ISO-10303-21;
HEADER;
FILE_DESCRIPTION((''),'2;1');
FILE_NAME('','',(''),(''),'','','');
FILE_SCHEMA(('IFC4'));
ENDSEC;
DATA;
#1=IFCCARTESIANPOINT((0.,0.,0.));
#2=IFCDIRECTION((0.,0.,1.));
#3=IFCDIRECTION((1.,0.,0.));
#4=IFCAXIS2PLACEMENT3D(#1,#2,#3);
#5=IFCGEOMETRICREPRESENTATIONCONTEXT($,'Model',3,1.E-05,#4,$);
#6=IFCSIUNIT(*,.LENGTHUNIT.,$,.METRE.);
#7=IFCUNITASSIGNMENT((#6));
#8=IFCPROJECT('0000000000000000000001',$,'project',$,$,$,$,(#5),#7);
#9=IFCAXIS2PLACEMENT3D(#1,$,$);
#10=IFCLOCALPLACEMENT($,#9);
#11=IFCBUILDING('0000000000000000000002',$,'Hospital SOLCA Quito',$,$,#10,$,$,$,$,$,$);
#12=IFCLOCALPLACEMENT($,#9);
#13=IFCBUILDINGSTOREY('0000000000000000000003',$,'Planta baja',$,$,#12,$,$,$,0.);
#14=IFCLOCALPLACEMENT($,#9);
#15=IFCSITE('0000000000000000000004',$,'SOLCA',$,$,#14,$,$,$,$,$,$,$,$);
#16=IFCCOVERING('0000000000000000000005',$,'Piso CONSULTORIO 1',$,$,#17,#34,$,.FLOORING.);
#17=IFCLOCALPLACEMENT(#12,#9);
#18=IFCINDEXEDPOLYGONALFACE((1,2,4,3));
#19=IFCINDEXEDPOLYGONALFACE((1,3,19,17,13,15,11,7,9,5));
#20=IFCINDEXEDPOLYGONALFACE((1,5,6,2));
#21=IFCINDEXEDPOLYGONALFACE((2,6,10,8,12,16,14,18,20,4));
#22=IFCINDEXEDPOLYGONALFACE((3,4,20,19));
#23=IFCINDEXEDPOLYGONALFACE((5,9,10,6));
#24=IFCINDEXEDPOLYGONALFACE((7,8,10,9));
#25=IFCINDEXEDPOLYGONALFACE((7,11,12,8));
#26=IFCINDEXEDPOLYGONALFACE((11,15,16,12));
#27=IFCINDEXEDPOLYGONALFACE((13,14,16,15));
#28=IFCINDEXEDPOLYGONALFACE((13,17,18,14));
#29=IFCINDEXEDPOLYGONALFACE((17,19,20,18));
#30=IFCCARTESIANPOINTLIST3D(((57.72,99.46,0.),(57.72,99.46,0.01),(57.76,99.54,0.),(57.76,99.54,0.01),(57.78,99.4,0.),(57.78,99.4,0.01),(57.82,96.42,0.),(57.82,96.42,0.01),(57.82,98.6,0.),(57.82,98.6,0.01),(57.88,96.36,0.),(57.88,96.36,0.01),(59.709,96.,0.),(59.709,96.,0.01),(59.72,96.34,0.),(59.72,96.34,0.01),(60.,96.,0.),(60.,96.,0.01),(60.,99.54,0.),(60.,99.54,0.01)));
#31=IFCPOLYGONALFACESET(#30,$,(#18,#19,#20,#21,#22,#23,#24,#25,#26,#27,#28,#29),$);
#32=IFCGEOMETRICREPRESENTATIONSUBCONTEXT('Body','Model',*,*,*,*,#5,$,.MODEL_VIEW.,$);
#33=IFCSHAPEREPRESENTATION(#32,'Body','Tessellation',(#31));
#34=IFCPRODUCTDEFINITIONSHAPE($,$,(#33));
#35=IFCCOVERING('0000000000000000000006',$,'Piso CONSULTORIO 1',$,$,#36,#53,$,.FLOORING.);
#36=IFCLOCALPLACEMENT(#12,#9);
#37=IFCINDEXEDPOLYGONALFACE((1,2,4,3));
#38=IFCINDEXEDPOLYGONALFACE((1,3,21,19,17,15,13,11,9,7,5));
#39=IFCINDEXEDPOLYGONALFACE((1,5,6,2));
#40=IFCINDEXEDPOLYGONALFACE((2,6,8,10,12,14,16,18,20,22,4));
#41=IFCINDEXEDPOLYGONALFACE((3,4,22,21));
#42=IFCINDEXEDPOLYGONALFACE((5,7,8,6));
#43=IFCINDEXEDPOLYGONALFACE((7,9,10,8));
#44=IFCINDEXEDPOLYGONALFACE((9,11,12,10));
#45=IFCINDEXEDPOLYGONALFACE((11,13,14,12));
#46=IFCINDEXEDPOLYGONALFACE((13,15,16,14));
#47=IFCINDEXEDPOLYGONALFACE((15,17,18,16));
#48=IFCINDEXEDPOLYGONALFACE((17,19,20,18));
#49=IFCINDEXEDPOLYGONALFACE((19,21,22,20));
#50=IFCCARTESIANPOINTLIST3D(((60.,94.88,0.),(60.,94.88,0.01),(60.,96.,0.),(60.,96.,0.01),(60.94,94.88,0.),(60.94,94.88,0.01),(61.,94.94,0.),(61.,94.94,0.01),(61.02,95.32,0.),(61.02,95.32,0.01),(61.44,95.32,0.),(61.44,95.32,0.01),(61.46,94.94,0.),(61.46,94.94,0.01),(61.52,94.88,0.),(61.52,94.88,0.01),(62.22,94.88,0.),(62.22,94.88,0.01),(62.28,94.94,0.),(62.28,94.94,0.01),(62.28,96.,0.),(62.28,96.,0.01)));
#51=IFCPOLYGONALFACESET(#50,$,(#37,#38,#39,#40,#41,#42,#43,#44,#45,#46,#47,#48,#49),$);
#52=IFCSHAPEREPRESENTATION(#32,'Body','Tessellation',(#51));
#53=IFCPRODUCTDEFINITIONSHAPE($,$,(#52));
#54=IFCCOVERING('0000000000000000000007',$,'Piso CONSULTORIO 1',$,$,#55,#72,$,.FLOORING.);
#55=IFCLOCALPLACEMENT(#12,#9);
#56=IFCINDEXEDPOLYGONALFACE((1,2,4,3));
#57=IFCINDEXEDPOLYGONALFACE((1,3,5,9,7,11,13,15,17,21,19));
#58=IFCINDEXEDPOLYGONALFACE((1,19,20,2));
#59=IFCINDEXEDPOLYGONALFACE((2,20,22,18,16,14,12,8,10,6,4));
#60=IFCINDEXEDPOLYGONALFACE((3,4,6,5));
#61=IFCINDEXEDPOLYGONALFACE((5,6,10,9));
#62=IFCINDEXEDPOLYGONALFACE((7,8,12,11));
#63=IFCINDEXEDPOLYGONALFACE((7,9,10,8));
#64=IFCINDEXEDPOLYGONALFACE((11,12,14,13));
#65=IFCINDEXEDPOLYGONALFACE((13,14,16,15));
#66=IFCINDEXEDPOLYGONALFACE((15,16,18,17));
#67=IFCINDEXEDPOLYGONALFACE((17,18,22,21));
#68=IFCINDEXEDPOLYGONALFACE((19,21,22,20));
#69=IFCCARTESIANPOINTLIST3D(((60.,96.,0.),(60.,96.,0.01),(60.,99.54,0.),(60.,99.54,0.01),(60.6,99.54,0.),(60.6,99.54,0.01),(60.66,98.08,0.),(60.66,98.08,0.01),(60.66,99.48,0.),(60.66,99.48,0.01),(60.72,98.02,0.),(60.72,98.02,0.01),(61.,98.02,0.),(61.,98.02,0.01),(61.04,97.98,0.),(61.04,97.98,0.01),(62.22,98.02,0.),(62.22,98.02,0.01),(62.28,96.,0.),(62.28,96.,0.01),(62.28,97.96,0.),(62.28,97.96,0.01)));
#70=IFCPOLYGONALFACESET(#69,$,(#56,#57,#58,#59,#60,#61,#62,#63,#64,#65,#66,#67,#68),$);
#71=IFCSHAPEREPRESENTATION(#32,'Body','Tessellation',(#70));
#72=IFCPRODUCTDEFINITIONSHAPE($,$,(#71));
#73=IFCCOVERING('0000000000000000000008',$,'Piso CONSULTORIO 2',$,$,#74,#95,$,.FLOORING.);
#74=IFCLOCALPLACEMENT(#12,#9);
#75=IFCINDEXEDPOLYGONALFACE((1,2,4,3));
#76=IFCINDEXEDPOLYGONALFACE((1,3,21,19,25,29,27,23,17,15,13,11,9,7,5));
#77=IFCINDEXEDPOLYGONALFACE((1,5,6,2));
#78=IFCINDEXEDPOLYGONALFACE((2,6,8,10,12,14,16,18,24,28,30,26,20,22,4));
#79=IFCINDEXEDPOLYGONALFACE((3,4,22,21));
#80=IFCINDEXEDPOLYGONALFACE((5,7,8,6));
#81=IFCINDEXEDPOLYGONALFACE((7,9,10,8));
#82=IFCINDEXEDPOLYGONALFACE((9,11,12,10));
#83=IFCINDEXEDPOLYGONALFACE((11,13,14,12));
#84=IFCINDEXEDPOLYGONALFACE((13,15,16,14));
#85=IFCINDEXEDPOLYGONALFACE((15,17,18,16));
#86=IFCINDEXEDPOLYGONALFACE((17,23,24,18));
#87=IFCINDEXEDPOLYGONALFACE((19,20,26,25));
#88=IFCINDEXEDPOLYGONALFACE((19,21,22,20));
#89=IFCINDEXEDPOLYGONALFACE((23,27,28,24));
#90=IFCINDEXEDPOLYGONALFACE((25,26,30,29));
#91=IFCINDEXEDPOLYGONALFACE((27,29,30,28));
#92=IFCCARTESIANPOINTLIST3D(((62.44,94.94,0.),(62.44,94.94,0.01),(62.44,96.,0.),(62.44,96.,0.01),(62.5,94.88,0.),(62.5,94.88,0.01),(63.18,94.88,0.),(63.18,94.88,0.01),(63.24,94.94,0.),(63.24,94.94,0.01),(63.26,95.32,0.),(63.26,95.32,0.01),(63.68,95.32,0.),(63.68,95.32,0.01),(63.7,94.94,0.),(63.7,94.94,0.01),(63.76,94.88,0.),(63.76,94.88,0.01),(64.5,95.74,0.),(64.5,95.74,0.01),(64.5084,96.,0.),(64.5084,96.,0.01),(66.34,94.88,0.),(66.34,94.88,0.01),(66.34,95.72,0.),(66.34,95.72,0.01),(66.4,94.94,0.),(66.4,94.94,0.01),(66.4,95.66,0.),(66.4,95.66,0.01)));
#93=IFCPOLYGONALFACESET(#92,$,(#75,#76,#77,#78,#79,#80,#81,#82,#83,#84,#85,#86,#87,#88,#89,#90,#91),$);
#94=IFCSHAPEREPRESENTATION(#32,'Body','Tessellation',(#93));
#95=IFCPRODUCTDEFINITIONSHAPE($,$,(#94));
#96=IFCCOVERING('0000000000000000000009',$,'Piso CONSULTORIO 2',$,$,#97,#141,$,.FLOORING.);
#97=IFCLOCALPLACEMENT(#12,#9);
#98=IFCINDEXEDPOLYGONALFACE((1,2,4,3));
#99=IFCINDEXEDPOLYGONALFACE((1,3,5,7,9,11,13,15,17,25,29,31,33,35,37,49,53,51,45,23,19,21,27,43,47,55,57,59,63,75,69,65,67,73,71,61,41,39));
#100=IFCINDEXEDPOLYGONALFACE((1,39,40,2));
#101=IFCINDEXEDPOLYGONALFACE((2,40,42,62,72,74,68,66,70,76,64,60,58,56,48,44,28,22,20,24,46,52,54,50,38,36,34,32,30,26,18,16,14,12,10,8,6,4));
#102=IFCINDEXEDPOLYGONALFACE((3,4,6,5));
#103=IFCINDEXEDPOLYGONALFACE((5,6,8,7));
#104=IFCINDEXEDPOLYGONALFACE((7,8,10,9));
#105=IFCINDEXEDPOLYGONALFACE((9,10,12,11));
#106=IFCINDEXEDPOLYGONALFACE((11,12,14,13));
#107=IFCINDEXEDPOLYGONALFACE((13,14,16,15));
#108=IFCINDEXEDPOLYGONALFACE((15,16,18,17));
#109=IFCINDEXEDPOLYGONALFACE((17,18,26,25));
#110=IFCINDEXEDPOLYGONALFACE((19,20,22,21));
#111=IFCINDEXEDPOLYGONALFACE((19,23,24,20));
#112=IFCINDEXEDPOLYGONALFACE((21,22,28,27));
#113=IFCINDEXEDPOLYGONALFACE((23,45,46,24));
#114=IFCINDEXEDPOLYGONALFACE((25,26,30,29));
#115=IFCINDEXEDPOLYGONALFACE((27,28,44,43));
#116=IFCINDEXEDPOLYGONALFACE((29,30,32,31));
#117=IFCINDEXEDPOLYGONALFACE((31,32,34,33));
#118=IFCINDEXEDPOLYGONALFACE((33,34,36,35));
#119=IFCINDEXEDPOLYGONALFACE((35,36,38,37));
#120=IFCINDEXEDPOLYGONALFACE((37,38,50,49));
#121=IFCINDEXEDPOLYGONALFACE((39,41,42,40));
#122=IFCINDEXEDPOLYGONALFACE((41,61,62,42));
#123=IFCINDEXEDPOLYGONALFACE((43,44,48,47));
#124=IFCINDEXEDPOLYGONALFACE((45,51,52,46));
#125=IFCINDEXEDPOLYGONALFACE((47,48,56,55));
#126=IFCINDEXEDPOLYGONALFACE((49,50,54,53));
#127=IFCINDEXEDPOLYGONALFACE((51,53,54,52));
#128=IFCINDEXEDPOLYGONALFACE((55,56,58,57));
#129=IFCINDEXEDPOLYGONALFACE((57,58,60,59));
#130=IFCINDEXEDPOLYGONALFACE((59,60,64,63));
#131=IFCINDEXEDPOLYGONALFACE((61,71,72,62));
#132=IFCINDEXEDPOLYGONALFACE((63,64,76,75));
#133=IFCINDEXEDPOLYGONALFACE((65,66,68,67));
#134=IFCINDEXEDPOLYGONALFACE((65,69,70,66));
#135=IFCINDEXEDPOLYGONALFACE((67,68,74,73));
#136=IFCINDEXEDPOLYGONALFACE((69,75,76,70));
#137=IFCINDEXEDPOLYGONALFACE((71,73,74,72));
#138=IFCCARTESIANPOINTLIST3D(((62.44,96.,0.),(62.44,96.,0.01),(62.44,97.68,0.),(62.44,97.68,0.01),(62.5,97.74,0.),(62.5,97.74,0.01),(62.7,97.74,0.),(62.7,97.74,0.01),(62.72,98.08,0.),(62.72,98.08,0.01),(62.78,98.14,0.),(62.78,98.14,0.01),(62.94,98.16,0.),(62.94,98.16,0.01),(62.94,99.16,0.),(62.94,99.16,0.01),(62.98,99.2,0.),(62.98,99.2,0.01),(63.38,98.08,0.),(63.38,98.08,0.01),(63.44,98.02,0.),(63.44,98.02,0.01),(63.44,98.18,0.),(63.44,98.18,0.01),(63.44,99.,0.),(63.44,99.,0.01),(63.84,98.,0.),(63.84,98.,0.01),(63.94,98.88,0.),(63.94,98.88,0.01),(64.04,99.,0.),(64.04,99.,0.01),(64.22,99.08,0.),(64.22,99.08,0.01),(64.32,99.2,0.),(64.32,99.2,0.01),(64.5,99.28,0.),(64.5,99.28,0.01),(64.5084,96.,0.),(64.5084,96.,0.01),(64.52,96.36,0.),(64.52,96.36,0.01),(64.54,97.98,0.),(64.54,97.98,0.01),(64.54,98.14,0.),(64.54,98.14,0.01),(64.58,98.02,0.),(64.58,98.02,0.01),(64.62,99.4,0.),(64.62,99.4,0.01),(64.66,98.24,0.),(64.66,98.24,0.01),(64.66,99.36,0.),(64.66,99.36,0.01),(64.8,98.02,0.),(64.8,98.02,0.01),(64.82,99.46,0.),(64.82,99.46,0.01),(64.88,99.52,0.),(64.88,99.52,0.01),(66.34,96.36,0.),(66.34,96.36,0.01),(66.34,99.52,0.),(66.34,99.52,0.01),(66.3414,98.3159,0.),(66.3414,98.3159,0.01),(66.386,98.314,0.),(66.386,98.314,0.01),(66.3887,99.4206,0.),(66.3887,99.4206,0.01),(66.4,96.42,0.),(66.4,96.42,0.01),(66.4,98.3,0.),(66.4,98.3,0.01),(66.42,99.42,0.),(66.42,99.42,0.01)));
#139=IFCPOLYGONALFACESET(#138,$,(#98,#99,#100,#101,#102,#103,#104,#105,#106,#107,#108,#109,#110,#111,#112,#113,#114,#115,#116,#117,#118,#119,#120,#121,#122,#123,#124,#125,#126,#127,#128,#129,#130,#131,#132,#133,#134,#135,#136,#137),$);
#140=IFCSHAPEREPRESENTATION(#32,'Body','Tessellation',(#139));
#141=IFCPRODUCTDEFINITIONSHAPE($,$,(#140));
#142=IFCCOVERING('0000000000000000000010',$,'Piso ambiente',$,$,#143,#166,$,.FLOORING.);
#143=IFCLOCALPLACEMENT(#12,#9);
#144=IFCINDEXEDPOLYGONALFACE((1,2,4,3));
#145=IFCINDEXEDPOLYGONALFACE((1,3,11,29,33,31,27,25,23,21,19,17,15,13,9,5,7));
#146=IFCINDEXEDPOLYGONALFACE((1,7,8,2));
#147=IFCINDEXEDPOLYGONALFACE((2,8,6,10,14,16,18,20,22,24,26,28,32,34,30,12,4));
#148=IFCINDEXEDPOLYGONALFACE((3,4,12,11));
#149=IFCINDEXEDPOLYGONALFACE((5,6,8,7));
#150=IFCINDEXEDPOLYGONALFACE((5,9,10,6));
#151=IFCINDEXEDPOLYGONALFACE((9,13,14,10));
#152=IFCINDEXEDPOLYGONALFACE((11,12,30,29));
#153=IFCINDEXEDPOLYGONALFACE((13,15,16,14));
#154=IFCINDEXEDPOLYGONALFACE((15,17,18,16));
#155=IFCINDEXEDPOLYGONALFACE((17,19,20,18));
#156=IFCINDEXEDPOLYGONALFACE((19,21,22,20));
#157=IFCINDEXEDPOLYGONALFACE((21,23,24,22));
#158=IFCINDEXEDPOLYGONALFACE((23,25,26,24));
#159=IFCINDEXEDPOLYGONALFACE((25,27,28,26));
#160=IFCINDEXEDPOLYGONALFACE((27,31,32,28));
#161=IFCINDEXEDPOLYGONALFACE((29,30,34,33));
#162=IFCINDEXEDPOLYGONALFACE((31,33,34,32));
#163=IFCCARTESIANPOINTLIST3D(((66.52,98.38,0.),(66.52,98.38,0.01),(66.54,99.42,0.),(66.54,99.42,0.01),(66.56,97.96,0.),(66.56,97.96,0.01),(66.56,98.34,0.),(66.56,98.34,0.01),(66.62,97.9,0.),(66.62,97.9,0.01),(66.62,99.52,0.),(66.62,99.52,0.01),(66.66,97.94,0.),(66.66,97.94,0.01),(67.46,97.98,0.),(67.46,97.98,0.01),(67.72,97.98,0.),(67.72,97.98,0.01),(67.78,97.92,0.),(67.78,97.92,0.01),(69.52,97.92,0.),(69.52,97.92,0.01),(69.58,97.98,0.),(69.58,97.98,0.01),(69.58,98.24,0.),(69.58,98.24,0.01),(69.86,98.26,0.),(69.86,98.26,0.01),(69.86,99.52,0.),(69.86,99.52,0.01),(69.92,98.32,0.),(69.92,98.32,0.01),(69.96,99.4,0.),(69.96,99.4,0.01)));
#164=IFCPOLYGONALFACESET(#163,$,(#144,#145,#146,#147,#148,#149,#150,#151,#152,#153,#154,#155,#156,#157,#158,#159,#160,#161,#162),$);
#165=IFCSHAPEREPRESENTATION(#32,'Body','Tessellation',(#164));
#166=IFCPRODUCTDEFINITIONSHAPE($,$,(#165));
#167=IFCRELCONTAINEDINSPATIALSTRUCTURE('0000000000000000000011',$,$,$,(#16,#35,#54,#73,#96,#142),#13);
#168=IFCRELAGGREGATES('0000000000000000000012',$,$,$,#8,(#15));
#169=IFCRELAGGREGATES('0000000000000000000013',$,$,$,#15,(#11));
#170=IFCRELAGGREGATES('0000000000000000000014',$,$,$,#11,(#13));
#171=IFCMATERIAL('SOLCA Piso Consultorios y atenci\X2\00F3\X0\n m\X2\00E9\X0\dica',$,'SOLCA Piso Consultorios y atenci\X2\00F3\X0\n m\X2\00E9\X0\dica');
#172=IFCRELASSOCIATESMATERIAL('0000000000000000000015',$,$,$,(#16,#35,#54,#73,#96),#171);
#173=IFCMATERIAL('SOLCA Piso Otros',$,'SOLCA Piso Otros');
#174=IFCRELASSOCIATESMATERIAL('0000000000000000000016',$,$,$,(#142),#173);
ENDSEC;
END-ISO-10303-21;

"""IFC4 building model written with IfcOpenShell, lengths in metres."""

from ifc_helpers import new_model, si_unit, origin, origin_with_axes, place, context, subcontext, project, spatial, polyline, outline, extrude, material, element, save


model = new_model("IFC4")

# Units and contexts
model_context = context("Model", 3, precision=1e-05, world=origin_with_axes())
body_context = subcontext(model_context, "Body", "Model", "MODEL_VIEW")
ifc_project = project(units=[si_unit("LENGTHUNIT", "METRE")], contexts=[model_context])

# Site, building, storey
site_placement = place(None, origin())
site = spatial("IfcSite", under=ifc_project, at=site_placement, Name="SOLCA")
building_placement = place(None, origin())
building = spatial("IfcBuilding", under=site, at=building_placement, Name="Hospital SOLCA Quito")
storey_placement = place(None, origin())
storey = spatial("IfcBuildingStorey", under=building, at=storey_placement, Name="Planta baja", Elevation=0.0)

# Coverings
ifc_material_1 = material(Name="SOLCA Piso Otros", Category="SOLCA Piso Otros")
ifc_material_2 = material(Name="SOLCA Piso Consultorios y atención médica", Category="SOLCA Piso Consultorios y atención médica")
covering_1_placement = place(storey_placement, origin_with_axes())
element("IfcCovering", 1, at=covering_1_placement, inside=storey, material=ifc_material_2, Name="Piso CONSULTORIO 1", PredefinedType="FLOORING", context=body_context, shape_type="SweptSolid", body=[
    extrude(outline(polyline([(60.0, 99.54), (60.0, 96.0), (59.709, 96.0), (59.72, 96.34), (57.88, 96.36), (57.82, 96.42), (57.82, 98.6), (57.78, 99.4), (57.72, 99.46), (57.76, 99.54), (60.0, 99.54)])), origin_with_axes(), (0.0, 0.0, 1.0), 0.01),
])
covering_2_placement = place(storey_placement, origin_with_axes())
element("IfcCovering", 2, at=covering_2_placement, inside=storey, material=ifc_material_2, Name="Piso CONSULTORIO 1", PredefinedType="FLOORING", context=body_context, shape_type="SweptSolid", body=[
    extrude(outline(polyline([(62.28, 94.94), (62.22, 94.88), (61.52, 94.88), (61.46, 94.94), (61.44, 95.32), (61.02, 95.32), (61.0, 94.94), (60.94, 94.88), (60.0, 94.88), (60.0, 96.0), (62.28, 96.0), (62.28, 94.94)])), origin_with_axes(), (0.0, 0.0, 1.0), 0.01),
])
covering_3_placement = place(storey_placement, origin_with_axes())
element("IfcCovering", 3, at=covering_3_placement, inside=storey, material=ifc_material_2, Name="Piso CONSULTORIO 1", PredefinedType="FLOORING", context=body_context, shape_type="SweptSolid", body=[
    extrude(outline(polyline([(60.6, 99.54), (60.66, 99.48), (60.66, 98.08), (60.72, 98.02), (61.0, 98.02), (61.04, 97.98), (62.22, 98.02), (62.28, 97.96), (62.28, 96.0), (60.0, 96.0), (60.0, 99.54), (60.6, 99.54)])), origin_with_axes(), (0.0, 0.0, 1.0), 0.01),
])
covering_4_placement = place(storey_placement, origin_with_axes())
element("IfcCovering", 4, at=covering_4_placement, inside=storey, material=ifc_material_2, Name="Piso CONSULTORIO 2", PredefinedType="FLOORING", context=body_context, shape_type="SweptSolid", body=[
    extrude(outline(polyline([(64.5, 95.74), (66.34, 95.72), (66.4, 95.66), (66.4, 94.94), (66.34, 94.88), (63.76, 94.88), (63.7, 94.94), (63.68, 95.32), (63.26, 95.32), (63.24, 94.94), (63.18, 94.88), (62.5, 94.88), (62.44, 94.94), (62.44, 96.0), (64.5084, 96.0), (64.5, 95.74)])), origin_with_axes(), (0.0, 0.0, 1.0), 0.01),
])
covering_5_placement = place(storey_placement, origin_with_axes())
element("IfcCovering", 5, at=covering_5_placement, inside=storey, material=ifc_material_2, Name="Piso CONSULTORIO 2", PredefinedType="FLOORING", context=body_context, shape_type="SweptSolid", body=[
    extrude(outline(polyline([(66.42, 99.42), (66.3887, 99.4206), (66.3414, 98.3159), (66.386, 98.314), (66.4, 98.3), (66.4, 96.42), (66.34, 96.36), (64.52, 96.36), (64.5084, 96.0), (62.44, 96.0), (62.44, 97.68), (62.5, 97.74), (62.7, 97.74), (62.72, 98.08), (62.78, 98.14), (62.94, 98.16), (62.94, 99.16), (62.98, 99.2), (63.44, 99.0), (63.94, 98.88), (64.04, 99.0), (64.22, 99.08), (64.32, 99.2), (64.5, 99.28), (64.62, 99.4), (64.66, 99.36), (64.66, 98.24), (64.54, 98.14), (63.44, 98.18), (63.38, 98.08), (63.44, 98.02), (63.84, 98.0), (64.54, 97.98), (64.58, 98.02), (64.8, 98.02), (64.82, 99.46), (64.88, 99.52), (66.34, 99.52), (66.42, 99.42)])), origin_with_axes(), (0.0, 0.0, 1.0), 0.01),
])
covering_6_placement = place(storey_placement, origin_with_axes())
element("IfcCovering", 6, at=covering_6_placement, inside=storey, material=ifc_material_1, Name="Piso ambiente", PredefinedType="FLOORING", context=body_context, shape_type="SweptSolid", body=[
    extrude(outline(polyline([(69.86, 99.52), (69.96, 99.4), (69.92, 98.32), (69.86, 98.26), (69.58, 98.24), (69.58, 97.98), (69.52, 97.92), (67.78, 97.92), (67.72, 97.98), (67.46, 97.98), (66.66, 97.94), (66.62, 97.9), (66.56, 97.96), (66.56, 98.34), (66.52, 98.38), (66.54, 99.42), (66.62, 99.52), (69.86, 99.52)])), origin_with_axes(), (0.0, 0.0, 1.0), 0.01),
])

save(model, "model.ifc")
